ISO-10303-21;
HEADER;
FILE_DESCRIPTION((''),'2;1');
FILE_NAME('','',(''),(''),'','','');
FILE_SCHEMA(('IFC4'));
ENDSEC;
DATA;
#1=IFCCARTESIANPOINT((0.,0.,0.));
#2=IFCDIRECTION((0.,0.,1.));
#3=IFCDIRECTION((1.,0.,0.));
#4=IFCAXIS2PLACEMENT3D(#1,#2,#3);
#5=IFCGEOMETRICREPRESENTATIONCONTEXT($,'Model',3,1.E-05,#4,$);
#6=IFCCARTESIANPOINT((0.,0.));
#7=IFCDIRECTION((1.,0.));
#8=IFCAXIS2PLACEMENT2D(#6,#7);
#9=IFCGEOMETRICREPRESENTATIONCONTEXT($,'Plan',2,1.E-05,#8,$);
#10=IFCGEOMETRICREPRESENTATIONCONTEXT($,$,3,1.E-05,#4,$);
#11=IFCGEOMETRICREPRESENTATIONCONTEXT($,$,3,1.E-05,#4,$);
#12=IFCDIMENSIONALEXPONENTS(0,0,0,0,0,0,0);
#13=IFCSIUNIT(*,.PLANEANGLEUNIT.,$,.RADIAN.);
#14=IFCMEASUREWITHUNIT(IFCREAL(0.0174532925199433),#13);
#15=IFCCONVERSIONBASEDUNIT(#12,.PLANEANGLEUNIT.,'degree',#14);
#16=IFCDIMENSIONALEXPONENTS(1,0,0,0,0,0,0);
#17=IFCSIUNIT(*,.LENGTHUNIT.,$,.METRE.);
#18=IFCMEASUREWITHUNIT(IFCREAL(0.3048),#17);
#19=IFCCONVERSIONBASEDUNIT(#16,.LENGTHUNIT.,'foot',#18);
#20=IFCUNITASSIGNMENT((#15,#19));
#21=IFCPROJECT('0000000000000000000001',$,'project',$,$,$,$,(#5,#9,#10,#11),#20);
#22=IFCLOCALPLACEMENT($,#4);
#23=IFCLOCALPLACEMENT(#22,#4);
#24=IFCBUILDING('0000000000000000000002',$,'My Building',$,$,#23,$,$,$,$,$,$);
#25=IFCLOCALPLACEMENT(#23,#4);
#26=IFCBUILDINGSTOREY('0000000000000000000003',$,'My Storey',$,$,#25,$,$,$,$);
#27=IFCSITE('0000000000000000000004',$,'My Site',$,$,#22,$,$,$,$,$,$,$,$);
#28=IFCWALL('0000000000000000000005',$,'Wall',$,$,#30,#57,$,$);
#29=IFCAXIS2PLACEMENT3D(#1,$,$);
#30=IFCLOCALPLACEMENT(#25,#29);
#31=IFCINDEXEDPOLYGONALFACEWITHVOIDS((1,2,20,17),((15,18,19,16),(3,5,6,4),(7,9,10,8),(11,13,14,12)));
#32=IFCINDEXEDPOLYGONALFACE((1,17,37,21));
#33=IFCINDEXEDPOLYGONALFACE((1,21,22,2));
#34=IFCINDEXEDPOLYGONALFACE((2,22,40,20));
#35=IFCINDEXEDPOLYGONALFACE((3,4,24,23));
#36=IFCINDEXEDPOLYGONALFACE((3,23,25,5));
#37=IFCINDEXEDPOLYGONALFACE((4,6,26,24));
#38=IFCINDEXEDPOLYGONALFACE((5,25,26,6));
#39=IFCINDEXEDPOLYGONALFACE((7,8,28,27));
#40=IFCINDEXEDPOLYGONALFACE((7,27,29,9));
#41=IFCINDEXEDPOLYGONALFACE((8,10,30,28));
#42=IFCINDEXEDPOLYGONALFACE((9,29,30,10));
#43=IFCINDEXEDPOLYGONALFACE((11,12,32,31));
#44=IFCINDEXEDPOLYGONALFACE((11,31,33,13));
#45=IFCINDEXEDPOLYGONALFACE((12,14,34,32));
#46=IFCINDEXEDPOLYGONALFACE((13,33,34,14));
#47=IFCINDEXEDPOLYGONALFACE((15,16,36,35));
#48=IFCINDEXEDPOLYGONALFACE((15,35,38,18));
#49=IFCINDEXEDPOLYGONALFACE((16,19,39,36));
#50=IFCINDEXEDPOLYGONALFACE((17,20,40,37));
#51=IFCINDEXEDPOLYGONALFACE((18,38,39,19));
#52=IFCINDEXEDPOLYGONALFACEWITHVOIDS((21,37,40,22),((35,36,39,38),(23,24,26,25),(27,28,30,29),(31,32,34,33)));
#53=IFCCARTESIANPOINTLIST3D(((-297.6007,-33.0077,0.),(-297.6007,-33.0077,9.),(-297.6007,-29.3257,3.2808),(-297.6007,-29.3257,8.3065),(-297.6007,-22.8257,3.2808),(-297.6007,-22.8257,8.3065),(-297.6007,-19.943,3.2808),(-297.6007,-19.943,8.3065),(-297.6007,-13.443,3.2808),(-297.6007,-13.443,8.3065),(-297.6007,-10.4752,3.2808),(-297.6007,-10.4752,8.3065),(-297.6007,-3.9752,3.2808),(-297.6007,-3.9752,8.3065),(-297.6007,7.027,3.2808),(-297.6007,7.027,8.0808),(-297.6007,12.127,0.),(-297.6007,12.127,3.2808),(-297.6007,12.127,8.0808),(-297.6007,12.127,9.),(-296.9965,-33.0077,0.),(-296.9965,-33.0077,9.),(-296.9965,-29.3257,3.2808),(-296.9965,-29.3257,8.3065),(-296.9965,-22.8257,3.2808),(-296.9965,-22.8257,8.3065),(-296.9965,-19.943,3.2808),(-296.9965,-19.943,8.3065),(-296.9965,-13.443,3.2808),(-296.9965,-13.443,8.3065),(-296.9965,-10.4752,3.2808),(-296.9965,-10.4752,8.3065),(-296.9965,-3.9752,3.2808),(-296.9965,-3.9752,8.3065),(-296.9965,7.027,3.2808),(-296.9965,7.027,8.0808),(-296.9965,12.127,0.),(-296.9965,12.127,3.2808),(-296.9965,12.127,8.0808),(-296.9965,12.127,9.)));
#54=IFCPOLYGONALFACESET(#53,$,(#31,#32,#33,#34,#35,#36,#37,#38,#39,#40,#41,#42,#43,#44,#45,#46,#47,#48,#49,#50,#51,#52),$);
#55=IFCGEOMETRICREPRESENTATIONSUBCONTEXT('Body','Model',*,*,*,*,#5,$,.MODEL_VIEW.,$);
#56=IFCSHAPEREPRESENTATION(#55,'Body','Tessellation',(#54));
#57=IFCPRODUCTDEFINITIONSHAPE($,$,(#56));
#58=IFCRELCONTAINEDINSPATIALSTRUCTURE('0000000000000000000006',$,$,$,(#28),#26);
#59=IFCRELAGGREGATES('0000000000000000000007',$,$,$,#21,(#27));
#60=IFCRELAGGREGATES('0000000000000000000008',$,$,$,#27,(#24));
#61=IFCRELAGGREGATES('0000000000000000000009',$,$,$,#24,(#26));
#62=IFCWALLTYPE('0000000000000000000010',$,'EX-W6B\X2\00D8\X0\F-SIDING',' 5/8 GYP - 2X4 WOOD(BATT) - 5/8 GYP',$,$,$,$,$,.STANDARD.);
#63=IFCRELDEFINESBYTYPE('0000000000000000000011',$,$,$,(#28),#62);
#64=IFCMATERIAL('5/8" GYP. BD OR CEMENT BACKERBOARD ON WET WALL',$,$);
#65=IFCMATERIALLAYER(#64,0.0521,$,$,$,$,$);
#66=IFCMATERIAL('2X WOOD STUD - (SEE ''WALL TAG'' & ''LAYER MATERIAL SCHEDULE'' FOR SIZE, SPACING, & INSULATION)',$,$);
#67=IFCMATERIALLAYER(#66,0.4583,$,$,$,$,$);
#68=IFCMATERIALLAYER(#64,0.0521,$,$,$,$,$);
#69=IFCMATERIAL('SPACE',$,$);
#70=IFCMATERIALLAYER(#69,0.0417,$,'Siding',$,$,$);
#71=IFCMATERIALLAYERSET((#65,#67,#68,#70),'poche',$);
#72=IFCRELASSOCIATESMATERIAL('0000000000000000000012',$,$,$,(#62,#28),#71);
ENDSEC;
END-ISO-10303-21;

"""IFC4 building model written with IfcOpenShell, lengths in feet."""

from ifc_helpers import new_model, entity, si_unit, converted_unit, frame, origin_with_axes, origin_2d_with_axis, place, context, subcontext, project, spatial, line, indexed_curve, outline, extrude, source, transform, mapped, material, layer, layer_set, layer_usage, type_object, element, save


model = new_model("IFC4")

# Units and contexts
model_context = context("Model", 3, precision=1e-05, world=origin_with_axes())
plan_context = context("Plan", 2, precision=1e-05, world=origin_2d_with_axis())
context_of_model_1 = context(None, 3, precision=1e-05, world=origin_with_axes())
context_of_model_2 = context(None, 3, precision=1e-05, world=origin_with_axes())
body_context = subcontext(model_context, "Body", "Model", "MODEL_VIEW")
ifc_project = project(units=[converted_unit("PLANEANGLEUNIT", "degree", entity("IfcReal", 0.0174532925199433), si_unit("PLANEANGLEUNIT", "RADIAN"), dimensions=[0, 0, 0, 0, 0, 0, 0]), converted_unit("LENGTHUNIT", "foot", entity("IfcReal", 0.3048), si_unit("LENGTHUNIT", "METRE"), dimensions=[1, 0, 0, 0, 0, 0, 0])], contexts=[model_context, plan_context, context_of_model_1, context_of_model_2])

# Site, building, storey
site_placement = place(None, origin_with_axes())
site = spatial("IfcSite", under=ifc_project, at=site_placement, Name="My Site")
building_placement = place(site_placement, origin_with_axes())
building = spatial("IfcBuilding", under=site, at=building_placement, Name="My Building")
storey_placement = place(building_placement, origin_with_axes())
storey = spatial("IfcBuildingStorey", under=building, at=storey_placement, Name="My Storey")

# Shared definitions
ifc_material_1 = material(Name="5/8\" GYP. BD OR CEMENT BACKERBOARD ON WET WALL")
ifc_material_2 = material(Name="2X WOOD STUD - (SEE 'WALL TAG' & 'LAYER MATERIAL SCHEDULE' FOR SIZE, SPACING, & INSULATION)")

# Shared definitions
ifc_material_3 = material(Name="SPACE")
ifc_layer_1 = layer(ifc_material_1, 0.0521)
ifc_layer_2 = layer(ifc_material_2, 0.4583)
ifc_layer_3 = layer(ifc_material_1, 0.0521)
ifc_layer_4 = layer(ifc_material_3, 0.0417, Name="Siding")
ifc_layer_set_1 = layer_set([ifc_layer_1, ifc_layer_2, ifc_layer_3, ifc_layer_4], Name="poche")
wall_type_1 = type_object("IfcWallType", Name="EX-W6BØF-SIDING", Description=" 5/8 GYP - 2X4 WOOD(BATT) - 5/8 GYP", PredefinedType="STANDARD", material=ifc_layer_set_1)

# Wall, openings
ifc_layer_usage_1 = layer_usage(ifc_layer_set_1, "AXIS2", "POSITIVE", 0.0)
wall_1_placement = place(storey_placement, frame((-296.9965, -33.0077, 0.0), z_axis=(0.0, 0.0, 1.0), x_axis=(0.0, 1.0, 0.0)))
wall_1 = element("IfcWall", 1, at=wall_1_placement, inside=storey, type_object=wall_type_1, material=ifc_layer_usage_1, Name="Wall", context=body_context, shape_type="SweptSolid", body=[
    extrude(outline(indexed_curve([(0.0, 0.0), (0.0, 0.6042), (45.1348, 0.6042), (45.1348, 0.0), (0.0, 0.0)], self_intersect=False)), origin_with_axes(), (0.0, 0.0, 1.0), 9.0),
])
shared_shape_1 = source(origin_with_axes(), body_context, "Body", "SweptSolid", [
    extrude(outline(indexed_curve([(0.0, 0.0), (5.1, 0.0), (5.1, 4.8), (0.0, 4.8)], segments=[line(1, 2, 3, 4, 1)])), frame((0.0, -0.3281, 0.0), z_axis=(0.0, -1.0, 0.0), x_axis=(1.0, 0.0, 0.0)), (0.0, 0.0, -1.0), 1.2603),
])
opening_1_placement = place(wall_1_placement, frame((40.0348, 0.0, 3.2808), z_axis=(0.0, 0.0, 1.0), x_axis=(1.0, 0.0, 0.0)))
element("IfcOpeningElement", 2, at=opening_1_placement, cuts=wall_1, PredefinedType="OPENING", context=body_context, shape_type="MappedRepresentation", body=[
    mapped(shared_shape_1, transform((0.0, 0.0, 0.0), x_axis=(1.0, 0.0, 0.0), y_axis=(0.0, 1.0, 0.0), z_axis=(0.0, 0.0, 1.0), scale=1.0)),
])
shared_shape_2 = source(origin_with_axes(), body_context, "Body", "SweptSolid", [
    extrude(outline(indexed_curve([(0.0, 0.0), (6.5, 0.0), (6.5, 5.0257), (0.0, 5.0257)], segments=[line(1, 2, 3, 4, 1)])), frame((0.0, -0.3281, 0.0), z_axis=(0.0, -1.0, 0.0), x_axis=(1.0, 0.0, 0.0)), (0.0, 0.0, -1.0), 1.2603),
])
opening_2_placement = place(wall_1_placement, frame((22.5325, 0.0, 3.2808), z_axis=(0.0, 0.0, 1.0), x_axis=(1.0, 0.0, 0.0)))
element("IfcOpeningElement", 3, at=opening_2_placement, cuts=wall_1, PredefinedType="OPENING", context=body_context, shape_type="MappedRepresentation", body=[
    mapped(shared_shape_2, transform((0.0, 0.0, 0.0), x_axis=(1.0, 0.0, 0.0), y_axis=(0.0, 1.0, 0.0), z_axis=(0.0, 0.0, 1.0), scale=1.0)),
])
opening_3_placement = place(wall_1_placement, frame((13.0647, 0.0, 3.2808), z_axis=(0.0, 0.0, 1.0), x_axis=(1.0, 0.0, 0.0)))
element("IfcOpeningElement", 4, at=opening_3_placement, cuts=wall_1, PredefinedType="OPENING", context=body_context, shape_type="MappedRepresentation", body=[
    mapped(shared_shape_2, transform((0.0, 0.0, 0.0), x_axis=(1.0, 0.0, 0.0), y_axis=(0.0, 1.0, 0.0), z_axis=(0.0, 0.0, 1.0), scale=1.0)),
])
opening_4_placement = place(wall_1_placement, frame((3.682, 0.0, 3.2808), z_axis=(0.0, 0.0, 1.0), x_axis=(1.0, 0.0, 0.0)))
element("IfcOpeningElement", 5, at=opening_4_placement, cuts=wall_1, PredefinedType="OPENING", context=body_context, shape_type="MappedRepresentation", body=[
    mapped(shared_shape_2, transform((0.0, 0.0, 0.0), x_axis=(1.0, 0.0, 0.0), y_axis=(0.0, 1.0, 0.0), z_axis=(0.0, 0.0, 1.0), scale=1.0)),
])

save(model, "model.ifc")
